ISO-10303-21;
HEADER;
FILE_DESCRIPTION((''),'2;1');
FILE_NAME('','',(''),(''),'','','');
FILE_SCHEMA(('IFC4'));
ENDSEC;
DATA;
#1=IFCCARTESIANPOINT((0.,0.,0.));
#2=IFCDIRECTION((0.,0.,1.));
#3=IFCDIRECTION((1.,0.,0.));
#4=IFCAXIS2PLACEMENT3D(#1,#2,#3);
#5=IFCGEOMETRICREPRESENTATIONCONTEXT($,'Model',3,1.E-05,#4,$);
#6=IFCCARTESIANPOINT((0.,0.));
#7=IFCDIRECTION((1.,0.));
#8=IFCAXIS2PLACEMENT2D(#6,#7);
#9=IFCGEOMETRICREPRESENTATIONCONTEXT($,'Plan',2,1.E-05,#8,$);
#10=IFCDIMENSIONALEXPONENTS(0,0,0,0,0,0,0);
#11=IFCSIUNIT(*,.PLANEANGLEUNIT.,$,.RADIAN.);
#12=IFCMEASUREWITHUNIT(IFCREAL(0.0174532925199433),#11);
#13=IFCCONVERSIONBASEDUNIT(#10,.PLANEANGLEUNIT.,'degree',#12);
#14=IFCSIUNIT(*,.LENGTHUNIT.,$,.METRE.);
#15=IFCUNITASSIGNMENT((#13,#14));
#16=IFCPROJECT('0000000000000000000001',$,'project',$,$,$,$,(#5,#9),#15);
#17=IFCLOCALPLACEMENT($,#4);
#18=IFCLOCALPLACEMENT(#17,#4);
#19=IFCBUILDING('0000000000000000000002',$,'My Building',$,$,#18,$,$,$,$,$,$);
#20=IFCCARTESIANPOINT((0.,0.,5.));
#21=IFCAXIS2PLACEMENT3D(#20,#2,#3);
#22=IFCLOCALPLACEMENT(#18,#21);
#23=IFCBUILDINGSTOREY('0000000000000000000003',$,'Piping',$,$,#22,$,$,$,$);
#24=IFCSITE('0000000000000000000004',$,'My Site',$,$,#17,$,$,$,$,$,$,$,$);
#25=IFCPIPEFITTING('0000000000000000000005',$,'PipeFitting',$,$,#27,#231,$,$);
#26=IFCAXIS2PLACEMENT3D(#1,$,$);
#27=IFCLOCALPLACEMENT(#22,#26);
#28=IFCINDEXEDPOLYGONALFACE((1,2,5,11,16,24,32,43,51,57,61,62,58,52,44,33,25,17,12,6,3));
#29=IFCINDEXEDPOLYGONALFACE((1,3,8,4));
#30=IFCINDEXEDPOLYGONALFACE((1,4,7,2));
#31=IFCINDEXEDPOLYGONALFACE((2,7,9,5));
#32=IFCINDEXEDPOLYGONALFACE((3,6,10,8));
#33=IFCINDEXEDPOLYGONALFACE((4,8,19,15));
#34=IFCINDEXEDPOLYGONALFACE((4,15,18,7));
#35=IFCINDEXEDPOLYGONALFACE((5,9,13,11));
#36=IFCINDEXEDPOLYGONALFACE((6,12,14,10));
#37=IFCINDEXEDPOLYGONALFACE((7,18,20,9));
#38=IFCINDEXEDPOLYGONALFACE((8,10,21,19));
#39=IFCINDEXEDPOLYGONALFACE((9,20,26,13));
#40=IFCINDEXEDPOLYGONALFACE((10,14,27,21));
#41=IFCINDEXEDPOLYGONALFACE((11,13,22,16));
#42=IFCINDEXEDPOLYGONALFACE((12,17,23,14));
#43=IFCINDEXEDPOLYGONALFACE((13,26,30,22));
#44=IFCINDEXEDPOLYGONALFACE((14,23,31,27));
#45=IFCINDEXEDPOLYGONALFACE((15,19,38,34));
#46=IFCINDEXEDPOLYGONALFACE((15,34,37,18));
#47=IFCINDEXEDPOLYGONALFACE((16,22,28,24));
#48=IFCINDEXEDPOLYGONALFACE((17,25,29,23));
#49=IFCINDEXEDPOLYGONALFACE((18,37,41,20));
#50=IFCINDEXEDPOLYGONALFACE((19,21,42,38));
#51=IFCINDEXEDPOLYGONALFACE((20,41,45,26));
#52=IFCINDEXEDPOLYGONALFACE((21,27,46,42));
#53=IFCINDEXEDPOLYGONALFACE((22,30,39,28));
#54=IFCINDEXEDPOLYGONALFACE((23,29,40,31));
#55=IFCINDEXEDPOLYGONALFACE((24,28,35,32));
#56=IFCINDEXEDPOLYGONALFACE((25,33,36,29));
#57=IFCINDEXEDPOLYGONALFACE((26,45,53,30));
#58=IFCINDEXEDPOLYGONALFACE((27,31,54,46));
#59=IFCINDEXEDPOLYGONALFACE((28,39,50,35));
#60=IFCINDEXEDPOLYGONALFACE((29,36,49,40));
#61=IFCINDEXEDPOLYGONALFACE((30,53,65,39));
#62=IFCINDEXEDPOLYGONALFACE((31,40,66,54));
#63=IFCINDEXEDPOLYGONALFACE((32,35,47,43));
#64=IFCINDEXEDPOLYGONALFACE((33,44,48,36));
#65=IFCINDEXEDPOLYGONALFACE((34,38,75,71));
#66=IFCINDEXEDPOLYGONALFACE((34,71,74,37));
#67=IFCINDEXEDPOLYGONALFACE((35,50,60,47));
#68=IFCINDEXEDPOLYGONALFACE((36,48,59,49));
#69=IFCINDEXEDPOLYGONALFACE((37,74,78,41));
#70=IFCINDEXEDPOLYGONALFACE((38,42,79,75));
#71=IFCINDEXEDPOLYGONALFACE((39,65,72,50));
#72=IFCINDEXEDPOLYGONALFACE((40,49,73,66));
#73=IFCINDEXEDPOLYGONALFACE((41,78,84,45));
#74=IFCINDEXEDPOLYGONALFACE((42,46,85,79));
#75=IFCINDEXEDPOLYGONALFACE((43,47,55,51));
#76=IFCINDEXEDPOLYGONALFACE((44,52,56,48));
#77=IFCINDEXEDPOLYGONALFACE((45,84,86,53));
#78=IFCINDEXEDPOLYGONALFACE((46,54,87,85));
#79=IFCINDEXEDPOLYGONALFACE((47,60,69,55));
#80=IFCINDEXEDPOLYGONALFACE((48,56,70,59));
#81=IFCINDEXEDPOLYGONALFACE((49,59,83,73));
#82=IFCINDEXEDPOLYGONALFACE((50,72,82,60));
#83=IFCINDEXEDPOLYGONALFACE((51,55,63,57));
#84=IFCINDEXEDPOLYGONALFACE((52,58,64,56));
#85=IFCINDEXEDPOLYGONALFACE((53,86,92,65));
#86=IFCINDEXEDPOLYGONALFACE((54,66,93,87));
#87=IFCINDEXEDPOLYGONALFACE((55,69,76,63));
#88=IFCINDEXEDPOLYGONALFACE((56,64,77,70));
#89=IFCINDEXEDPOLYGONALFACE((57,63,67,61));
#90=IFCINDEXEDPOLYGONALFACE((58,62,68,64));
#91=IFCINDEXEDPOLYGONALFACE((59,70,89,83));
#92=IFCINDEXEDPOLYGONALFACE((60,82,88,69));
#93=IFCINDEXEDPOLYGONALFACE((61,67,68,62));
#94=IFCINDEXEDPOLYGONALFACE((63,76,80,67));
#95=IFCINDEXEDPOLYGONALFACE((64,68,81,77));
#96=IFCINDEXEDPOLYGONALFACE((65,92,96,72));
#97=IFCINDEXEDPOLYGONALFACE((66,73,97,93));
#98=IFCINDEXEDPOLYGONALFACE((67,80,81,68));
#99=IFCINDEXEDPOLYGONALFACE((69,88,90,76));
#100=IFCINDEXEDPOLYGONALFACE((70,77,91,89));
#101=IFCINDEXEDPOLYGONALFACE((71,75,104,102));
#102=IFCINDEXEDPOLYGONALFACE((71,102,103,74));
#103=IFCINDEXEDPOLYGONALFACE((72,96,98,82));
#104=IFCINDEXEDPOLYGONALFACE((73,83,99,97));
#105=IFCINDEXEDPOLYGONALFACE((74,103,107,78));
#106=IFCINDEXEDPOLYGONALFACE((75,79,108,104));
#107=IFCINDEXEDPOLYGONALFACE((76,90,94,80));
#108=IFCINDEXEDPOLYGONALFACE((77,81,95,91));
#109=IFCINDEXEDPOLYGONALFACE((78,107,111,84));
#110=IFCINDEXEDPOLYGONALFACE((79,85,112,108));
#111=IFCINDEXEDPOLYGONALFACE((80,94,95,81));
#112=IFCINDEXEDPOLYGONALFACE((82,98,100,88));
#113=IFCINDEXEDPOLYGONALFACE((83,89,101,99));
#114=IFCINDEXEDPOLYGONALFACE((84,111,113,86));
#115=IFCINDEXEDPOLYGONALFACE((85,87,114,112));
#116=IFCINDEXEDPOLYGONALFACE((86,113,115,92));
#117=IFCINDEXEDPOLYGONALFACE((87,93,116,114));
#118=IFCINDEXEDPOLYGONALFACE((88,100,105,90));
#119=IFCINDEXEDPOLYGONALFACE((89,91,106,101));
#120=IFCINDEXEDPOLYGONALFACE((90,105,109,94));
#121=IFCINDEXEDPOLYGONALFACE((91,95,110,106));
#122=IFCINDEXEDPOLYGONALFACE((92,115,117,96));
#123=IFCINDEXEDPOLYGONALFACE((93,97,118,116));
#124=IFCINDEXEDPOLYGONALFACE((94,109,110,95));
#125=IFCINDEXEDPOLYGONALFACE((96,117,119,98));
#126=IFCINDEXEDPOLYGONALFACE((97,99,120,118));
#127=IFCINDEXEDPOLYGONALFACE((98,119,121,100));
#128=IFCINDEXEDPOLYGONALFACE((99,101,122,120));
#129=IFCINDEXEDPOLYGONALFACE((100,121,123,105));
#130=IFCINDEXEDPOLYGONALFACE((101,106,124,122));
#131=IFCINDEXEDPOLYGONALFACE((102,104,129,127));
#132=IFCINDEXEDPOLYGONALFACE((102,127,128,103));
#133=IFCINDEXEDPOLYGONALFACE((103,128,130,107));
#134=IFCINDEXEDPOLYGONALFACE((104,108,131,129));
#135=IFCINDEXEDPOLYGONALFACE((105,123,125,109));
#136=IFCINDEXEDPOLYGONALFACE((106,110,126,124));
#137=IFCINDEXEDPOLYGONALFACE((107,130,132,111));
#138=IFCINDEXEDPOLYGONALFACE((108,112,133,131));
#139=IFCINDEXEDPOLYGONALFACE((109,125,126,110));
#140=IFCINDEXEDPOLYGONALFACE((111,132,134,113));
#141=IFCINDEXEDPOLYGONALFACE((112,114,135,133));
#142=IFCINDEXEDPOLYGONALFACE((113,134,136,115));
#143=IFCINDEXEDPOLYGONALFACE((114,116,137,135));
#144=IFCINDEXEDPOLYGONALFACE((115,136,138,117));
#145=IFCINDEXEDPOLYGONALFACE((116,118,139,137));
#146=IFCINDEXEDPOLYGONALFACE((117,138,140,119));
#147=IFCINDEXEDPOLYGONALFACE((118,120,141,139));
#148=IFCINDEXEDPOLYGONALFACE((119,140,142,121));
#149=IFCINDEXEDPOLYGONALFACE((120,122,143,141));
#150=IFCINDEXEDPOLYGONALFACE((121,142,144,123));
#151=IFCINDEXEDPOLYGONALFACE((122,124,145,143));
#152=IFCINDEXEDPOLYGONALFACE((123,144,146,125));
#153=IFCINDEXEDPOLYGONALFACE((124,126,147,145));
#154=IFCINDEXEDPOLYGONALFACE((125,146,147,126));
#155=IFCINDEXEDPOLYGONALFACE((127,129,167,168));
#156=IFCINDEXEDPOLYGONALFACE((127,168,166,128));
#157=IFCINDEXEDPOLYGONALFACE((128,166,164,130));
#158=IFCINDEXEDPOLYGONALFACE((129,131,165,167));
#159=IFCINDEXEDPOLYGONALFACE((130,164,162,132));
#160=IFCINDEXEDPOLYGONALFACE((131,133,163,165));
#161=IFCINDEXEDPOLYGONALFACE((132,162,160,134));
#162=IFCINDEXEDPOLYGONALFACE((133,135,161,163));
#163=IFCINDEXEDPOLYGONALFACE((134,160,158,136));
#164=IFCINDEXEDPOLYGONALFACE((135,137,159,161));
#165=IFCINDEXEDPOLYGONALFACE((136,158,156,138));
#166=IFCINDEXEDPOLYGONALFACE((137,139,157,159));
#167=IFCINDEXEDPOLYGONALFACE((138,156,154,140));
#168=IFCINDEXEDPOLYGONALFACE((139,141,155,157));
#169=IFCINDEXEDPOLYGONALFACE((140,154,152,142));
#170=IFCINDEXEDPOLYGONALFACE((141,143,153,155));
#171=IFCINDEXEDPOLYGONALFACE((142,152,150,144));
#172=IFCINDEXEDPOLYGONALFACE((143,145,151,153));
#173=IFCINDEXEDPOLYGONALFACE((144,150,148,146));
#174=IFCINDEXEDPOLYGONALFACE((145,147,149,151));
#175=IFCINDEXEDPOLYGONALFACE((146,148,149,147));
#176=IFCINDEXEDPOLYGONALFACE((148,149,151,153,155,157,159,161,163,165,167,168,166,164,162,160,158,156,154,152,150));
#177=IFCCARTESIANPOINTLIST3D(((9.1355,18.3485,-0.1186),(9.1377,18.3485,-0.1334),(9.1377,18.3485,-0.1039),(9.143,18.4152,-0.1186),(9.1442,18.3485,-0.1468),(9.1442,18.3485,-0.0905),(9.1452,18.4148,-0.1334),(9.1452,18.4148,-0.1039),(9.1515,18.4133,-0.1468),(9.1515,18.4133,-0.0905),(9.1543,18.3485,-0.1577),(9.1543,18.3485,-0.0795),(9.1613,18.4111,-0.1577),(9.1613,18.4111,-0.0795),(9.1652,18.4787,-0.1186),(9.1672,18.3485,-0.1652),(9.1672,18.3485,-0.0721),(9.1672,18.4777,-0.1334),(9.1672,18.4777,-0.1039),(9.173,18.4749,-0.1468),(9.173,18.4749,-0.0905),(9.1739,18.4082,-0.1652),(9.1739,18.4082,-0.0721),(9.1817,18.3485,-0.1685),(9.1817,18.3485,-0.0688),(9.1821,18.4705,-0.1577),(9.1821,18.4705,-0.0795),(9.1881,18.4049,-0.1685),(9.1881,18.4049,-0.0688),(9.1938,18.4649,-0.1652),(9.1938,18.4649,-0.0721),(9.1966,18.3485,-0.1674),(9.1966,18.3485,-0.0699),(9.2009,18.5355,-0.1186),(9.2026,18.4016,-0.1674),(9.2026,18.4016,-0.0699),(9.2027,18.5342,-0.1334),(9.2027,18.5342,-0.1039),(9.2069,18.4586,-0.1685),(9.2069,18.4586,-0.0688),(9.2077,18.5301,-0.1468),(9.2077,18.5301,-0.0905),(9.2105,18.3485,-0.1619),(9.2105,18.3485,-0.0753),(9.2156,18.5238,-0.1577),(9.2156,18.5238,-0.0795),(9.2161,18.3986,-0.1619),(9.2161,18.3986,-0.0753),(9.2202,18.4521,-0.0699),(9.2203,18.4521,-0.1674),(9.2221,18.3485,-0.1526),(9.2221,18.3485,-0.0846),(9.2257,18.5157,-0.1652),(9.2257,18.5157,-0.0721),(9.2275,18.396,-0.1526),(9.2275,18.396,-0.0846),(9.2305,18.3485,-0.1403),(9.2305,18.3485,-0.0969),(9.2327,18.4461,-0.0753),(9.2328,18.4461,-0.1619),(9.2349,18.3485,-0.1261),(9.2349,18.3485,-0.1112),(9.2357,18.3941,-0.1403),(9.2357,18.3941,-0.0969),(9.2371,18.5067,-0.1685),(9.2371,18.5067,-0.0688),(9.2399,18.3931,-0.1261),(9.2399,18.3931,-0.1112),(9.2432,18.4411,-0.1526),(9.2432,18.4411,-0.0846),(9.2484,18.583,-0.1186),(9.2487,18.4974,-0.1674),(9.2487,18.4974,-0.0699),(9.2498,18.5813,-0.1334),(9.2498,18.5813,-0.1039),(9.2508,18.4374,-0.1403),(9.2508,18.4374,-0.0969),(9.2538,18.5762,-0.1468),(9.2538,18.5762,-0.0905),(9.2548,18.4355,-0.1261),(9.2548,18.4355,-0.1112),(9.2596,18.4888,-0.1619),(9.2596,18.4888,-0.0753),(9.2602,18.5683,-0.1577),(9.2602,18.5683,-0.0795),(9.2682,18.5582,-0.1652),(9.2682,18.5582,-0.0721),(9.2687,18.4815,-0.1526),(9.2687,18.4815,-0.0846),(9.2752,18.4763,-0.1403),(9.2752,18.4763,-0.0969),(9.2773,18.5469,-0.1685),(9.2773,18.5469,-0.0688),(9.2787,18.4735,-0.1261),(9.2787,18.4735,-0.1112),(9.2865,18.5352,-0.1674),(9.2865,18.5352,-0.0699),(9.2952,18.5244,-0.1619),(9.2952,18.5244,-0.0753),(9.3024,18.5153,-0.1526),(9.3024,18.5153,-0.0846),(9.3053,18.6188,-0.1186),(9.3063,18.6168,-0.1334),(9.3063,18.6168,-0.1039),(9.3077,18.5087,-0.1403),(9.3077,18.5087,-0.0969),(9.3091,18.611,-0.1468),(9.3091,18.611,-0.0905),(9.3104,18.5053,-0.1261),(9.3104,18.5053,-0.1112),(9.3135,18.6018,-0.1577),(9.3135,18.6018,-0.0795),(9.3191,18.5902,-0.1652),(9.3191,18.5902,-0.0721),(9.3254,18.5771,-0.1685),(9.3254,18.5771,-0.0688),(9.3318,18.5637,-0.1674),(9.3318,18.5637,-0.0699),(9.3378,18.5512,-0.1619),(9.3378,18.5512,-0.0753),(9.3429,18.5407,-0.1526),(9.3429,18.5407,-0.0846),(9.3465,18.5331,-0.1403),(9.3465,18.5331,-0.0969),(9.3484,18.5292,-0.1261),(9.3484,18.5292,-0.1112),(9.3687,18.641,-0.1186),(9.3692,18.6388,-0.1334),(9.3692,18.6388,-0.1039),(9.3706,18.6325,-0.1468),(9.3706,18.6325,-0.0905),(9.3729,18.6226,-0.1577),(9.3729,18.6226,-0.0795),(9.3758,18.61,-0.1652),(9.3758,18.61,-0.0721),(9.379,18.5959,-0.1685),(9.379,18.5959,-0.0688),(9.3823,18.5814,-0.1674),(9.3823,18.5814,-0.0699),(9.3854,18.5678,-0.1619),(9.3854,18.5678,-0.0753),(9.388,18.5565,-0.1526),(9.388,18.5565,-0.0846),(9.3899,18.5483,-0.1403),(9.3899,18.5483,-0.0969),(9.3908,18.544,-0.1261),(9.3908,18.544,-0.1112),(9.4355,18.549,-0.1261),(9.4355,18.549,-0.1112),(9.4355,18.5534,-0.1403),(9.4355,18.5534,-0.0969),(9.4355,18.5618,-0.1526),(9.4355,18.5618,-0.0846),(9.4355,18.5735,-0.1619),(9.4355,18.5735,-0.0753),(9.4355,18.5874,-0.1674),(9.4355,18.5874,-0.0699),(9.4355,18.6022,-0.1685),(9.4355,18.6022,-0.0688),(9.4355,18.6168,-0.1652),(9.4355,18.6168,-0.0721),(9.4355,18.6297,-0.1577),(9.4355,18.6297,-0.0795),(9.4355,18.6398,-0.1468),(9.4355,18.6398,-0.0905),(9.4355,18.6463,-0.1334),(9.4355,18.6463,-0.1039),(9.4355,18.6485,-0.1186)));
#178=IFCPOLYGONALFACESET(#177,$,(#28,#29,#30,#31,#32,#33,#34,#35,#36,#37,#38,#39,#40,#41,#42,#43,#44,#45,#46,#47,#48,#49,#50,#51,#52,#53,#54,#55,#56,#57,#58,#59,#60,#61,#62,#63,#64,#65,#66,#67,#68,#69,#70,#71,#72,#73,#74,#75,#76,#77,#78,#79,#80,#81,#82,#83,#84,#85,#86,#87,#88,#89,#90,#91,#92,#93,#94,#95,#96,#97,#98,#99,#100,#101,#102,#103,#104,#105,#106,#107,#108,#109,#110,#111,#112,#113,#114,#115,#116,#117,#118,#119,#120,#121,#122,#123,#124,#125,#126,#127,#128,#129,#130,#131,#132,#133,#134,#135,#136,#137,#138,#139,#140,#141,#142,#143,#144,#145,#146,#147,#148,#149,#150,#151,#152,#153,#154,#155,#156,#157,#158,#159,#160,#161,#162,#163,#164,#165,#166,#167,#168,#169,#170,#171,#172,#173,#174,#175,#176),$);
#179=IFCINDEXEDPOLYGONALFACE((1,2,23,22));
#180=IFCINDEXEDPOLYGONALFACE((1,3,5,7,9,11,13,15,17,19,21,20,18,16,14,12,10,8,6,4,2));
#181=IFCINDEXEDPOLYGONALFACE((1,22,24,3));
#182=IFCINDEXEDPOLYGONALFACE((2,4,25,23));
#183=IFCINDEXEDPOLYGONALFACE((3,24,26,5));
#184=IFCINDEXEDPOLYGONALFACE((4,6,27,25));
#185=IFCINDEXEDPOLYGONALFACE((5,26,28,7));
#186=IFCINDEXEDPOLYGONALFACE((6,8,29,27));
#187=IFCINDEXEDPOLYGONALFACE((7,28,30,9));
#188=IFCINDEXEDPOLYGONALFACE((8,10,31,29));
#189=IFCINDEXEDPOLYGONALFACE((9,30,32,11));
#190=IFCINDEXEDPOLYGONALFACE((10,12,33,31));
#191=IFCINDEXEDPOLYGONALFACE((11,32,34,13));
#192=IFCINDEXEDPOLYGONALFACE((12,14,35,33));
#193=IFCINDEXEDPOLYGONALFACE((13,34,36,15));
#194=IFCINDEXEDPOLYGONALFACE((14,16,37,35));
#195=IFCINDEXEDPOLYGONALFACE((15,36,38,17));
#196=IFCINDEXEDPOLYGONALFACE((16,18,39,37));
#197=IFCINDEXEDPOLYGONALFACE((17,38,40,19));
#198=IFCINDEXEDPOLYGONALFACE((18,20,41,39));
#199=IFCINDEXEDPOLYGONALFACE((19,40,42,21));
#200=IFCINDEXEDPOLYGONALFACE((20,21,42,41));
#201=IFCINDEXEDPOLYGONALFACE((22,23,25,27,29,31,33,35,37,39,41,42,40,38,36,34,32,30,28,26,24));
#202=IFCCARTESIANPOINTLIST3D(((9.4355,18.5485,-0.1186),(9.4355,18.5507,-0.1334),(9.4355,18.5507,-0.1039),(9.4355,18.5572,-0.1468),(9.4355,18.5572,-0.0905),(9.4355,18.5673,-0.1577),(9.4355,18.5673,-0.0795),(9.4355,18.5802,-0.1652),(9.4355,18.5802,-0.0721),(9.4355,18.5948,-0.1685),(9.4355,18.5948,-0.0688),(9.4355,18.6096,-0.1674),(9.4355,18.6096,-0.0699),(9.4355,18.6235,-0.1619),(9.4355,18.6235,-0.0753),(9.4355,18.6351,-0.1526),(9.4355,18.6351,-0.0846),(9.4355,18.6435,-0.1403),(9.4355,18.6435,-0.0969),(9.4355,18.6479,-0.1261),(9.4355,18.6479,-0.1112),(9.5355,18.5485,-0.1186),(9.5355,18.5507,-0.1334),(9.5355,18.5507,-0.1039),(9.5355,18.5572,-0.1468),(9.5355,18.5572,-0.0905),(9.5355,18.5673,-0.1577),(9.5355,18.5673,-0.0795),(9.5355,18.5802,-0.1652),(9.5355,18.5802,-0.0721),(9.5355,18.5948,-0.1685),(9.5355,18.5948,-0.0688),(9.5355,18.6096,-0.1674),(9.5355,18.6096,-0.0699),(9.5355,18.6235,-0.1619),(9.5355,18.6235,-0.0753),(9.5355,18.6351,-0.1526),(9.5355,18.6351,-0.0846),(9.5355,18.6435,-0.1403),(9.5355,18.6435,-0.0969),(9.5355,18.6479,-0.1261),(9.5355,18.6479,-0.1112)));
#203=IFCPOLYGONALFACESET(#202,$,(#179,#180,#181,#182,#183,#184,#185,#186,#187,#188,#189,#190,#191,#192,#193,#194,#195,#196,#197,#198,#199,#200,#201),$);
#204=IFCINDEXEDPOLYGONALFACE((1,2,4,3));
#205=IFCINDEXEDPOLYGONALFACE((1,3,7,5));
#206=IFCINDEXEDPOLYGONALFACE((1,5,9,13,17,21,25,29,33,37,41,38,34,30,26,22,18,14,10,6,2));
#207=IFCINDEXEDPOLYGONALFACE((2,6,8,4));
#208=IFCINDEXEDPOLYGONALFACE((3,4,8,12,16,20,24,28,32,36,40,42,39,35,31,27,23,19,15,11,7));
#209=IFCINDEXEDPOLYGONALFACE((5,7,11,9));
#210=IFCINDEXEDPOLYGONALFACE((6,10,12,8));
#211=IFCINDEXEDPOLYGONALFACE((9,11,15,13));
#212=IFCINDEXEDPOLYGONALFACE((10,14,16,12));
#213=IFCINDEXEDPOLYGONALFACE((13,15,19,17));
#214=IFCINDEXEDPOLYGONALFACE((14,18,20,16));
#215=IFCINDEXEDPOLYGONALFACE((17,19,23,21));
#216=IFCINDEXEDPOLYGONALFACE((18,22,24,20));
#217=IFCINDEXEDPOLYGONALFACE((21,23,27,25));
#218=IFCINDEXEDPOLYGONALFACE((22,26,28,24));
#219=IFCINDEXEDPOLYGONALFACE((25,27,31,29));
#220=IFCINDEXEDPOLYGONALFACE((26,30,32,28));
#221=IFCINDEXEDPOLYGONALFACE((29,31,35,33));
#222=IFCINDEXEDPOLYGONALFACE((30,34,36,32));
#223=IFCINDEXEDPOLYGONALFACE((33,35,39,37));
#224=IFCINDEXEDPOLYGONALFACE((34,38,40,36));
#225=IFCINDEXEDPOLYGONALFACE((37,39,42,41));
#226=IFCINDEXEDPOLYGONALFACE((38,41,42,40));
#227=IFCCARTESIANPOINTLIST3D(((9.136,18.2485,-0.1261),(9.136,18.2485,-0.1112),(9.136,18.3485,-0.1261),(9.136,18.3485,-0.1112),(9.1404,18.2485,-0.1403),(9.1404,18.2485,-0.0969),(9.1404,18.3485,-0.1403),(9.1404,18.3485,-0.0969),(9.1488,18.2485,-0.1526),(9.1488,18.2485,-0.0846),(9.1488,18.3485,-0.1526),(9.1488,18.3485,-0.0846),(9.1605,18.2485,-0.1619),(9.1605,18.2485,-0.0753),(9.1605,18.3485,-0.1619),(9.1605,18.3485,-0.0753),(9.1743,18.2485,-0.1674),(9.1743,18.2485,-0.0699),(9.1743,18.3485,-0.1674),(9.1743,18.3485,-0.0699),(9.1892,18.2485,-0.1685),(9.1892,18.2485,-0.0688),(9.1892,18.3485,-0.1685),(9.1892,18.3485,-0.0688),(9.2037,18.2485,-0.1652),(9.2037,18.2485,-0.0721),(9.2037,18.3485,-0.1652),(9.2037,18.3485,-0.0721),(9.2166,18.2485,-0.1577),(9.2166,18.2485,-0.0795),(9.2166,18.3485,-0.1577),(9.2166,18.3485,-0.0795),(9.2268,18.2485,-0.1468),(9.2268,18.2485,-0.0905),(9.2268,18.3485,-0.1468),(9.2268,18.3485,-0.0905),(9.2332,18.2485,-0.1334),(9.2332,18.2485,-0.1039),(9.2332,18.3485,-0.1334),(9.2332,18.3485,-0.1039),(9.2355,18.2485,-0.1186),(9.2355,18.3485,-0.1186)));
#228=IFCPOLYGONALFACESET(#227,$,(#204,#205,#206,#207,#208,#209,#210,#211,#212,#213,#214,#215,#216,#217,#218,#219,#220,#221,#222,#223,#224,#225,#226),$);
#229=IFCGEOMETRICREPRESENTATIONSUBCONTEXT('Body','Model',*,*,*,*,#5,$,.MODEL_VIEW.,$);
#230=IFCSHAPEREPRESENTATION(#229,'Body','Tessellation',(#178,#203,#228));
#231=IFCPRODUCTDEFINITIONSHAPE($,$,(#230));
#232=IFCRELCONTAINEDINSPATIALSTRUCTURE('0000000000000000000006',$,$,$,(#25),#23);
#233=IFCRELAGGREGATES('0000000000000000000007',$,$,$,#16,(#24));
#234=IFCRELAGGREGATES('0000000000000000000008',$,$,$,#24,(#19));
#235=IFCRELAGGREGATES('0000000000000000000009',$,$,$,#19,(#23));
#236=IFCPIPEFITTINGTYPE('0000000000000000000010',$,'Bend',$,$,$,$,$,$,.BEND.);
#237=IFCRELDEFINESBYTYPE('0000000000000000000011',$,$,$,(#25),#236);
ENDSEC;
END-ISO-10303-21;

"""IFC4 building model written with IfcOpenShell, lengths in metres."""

from ifc_helpers import new_model, entity, si_unit, converted_unit, frame, origin_with_axes, origin_2d_with_axis, place, context, subcontext, project, spatial, circle, extrude, source, transform, mapped, type_object, type_shapes, element, save


model = new_model("IFC4")

# Units and contexts
model_context = context("Model", 3, precision=1e-05, world=origin_with_axes())
plan_context = context("Plan", 2, precision=1e-05, world=origin_2d_with_axis())
body_context = subcontext(model_context, "Body", "Model", "MODEL_VIEW")
ifc_project = project(units=[converted_unit("PLANEANGLEUNIT", "degree", entity("IfcReal", 0.0174532925199433), si_unit("PLANEANGLEUNIT", "RADIAN"), dimensions=[0, 0, 0, 0, 0, 0, 0]), si_unit("LENGTHUNIT", "METRE")], contexts=[model_context, plan_context])

# Site, building, storey
site_placement = place(None, origin_with_axes())
site = spatial("IfcSite", under=ifc_project, at=site_placement, Name="My Site")
building_placement = place(site_placement, origin_with_axes())
building = spatial("IfcBuilding", under=site, at=building_placement, Name="My Building")
storey_placement = place(building_placement, frame((0.0, 0.0, 5.0), z_axis=(0.0, 0.0, 1.0), x_axis=(1.0, 0.0, 0.0)))
storey = spatial("IfcBuildingStorey", under=building, at=storey_placement, Name="Piping")

# Pipe fitting
pipe_fitting_type_1 = type_object("IfcPipeFittingType", Name="Bend", PredefinedType="BEND")
shared_shape = source(origin_with_axes(), body_context, "Body", "SolidModel", [
    entity("IfcSweptDiskSolid", entity("IfcIndexedPolyCurve", entity("IfcCartesianPointList3D", [[0.0, 0.0, -0.1], [0.0732, 0.0, -0.2768], [0.25, 0.0, -0.35]]), [entity("IfcArcIndex", [1, 2, 3])]), 0.05),
    extrude(circle(Radius=0.05), origin_with_axes(), (0.0, 0.0, -1.0), 0.1),
    extrude(circle(Radius=0.05), frame((0.25, 0.0, -0.35), z_axis=(1.0, 0.0, 0.0), x_axis=(0.0, 0.0, 1.0)), (0.0, 0.0, 1.0), 0.1),
])
type_shapes(pipe_fitting_type_1, [shared_shape])
for number, where, z_axis, x_axis, name in (
    (1, (9.5355, 18.5985, -0.1186), (1.0, -0.000001, 0.000001), (-0.000001, -1.0, 0.0), "PipeFitting"),
):
    element("IfcPipeFitting", number, at=place(storey_placement, frame(where, z_axis=z_axis, x_axis=x_axis)), inside=storey, type_object=pipe_fitting_type_1, Name=name, context=body_context, shape_type="MappedRepresentation", body=[
        mapped(shared_shape, transform((0.0, 0.0, 0.0), x_axis=(1.0, 0.0, 0.0), y_axis=(0.0, 1.0, 0.0), z_axis=(0.0, 0.0, 1.0), scale=1.0)),
    ])

save(model, "model.ifc")
